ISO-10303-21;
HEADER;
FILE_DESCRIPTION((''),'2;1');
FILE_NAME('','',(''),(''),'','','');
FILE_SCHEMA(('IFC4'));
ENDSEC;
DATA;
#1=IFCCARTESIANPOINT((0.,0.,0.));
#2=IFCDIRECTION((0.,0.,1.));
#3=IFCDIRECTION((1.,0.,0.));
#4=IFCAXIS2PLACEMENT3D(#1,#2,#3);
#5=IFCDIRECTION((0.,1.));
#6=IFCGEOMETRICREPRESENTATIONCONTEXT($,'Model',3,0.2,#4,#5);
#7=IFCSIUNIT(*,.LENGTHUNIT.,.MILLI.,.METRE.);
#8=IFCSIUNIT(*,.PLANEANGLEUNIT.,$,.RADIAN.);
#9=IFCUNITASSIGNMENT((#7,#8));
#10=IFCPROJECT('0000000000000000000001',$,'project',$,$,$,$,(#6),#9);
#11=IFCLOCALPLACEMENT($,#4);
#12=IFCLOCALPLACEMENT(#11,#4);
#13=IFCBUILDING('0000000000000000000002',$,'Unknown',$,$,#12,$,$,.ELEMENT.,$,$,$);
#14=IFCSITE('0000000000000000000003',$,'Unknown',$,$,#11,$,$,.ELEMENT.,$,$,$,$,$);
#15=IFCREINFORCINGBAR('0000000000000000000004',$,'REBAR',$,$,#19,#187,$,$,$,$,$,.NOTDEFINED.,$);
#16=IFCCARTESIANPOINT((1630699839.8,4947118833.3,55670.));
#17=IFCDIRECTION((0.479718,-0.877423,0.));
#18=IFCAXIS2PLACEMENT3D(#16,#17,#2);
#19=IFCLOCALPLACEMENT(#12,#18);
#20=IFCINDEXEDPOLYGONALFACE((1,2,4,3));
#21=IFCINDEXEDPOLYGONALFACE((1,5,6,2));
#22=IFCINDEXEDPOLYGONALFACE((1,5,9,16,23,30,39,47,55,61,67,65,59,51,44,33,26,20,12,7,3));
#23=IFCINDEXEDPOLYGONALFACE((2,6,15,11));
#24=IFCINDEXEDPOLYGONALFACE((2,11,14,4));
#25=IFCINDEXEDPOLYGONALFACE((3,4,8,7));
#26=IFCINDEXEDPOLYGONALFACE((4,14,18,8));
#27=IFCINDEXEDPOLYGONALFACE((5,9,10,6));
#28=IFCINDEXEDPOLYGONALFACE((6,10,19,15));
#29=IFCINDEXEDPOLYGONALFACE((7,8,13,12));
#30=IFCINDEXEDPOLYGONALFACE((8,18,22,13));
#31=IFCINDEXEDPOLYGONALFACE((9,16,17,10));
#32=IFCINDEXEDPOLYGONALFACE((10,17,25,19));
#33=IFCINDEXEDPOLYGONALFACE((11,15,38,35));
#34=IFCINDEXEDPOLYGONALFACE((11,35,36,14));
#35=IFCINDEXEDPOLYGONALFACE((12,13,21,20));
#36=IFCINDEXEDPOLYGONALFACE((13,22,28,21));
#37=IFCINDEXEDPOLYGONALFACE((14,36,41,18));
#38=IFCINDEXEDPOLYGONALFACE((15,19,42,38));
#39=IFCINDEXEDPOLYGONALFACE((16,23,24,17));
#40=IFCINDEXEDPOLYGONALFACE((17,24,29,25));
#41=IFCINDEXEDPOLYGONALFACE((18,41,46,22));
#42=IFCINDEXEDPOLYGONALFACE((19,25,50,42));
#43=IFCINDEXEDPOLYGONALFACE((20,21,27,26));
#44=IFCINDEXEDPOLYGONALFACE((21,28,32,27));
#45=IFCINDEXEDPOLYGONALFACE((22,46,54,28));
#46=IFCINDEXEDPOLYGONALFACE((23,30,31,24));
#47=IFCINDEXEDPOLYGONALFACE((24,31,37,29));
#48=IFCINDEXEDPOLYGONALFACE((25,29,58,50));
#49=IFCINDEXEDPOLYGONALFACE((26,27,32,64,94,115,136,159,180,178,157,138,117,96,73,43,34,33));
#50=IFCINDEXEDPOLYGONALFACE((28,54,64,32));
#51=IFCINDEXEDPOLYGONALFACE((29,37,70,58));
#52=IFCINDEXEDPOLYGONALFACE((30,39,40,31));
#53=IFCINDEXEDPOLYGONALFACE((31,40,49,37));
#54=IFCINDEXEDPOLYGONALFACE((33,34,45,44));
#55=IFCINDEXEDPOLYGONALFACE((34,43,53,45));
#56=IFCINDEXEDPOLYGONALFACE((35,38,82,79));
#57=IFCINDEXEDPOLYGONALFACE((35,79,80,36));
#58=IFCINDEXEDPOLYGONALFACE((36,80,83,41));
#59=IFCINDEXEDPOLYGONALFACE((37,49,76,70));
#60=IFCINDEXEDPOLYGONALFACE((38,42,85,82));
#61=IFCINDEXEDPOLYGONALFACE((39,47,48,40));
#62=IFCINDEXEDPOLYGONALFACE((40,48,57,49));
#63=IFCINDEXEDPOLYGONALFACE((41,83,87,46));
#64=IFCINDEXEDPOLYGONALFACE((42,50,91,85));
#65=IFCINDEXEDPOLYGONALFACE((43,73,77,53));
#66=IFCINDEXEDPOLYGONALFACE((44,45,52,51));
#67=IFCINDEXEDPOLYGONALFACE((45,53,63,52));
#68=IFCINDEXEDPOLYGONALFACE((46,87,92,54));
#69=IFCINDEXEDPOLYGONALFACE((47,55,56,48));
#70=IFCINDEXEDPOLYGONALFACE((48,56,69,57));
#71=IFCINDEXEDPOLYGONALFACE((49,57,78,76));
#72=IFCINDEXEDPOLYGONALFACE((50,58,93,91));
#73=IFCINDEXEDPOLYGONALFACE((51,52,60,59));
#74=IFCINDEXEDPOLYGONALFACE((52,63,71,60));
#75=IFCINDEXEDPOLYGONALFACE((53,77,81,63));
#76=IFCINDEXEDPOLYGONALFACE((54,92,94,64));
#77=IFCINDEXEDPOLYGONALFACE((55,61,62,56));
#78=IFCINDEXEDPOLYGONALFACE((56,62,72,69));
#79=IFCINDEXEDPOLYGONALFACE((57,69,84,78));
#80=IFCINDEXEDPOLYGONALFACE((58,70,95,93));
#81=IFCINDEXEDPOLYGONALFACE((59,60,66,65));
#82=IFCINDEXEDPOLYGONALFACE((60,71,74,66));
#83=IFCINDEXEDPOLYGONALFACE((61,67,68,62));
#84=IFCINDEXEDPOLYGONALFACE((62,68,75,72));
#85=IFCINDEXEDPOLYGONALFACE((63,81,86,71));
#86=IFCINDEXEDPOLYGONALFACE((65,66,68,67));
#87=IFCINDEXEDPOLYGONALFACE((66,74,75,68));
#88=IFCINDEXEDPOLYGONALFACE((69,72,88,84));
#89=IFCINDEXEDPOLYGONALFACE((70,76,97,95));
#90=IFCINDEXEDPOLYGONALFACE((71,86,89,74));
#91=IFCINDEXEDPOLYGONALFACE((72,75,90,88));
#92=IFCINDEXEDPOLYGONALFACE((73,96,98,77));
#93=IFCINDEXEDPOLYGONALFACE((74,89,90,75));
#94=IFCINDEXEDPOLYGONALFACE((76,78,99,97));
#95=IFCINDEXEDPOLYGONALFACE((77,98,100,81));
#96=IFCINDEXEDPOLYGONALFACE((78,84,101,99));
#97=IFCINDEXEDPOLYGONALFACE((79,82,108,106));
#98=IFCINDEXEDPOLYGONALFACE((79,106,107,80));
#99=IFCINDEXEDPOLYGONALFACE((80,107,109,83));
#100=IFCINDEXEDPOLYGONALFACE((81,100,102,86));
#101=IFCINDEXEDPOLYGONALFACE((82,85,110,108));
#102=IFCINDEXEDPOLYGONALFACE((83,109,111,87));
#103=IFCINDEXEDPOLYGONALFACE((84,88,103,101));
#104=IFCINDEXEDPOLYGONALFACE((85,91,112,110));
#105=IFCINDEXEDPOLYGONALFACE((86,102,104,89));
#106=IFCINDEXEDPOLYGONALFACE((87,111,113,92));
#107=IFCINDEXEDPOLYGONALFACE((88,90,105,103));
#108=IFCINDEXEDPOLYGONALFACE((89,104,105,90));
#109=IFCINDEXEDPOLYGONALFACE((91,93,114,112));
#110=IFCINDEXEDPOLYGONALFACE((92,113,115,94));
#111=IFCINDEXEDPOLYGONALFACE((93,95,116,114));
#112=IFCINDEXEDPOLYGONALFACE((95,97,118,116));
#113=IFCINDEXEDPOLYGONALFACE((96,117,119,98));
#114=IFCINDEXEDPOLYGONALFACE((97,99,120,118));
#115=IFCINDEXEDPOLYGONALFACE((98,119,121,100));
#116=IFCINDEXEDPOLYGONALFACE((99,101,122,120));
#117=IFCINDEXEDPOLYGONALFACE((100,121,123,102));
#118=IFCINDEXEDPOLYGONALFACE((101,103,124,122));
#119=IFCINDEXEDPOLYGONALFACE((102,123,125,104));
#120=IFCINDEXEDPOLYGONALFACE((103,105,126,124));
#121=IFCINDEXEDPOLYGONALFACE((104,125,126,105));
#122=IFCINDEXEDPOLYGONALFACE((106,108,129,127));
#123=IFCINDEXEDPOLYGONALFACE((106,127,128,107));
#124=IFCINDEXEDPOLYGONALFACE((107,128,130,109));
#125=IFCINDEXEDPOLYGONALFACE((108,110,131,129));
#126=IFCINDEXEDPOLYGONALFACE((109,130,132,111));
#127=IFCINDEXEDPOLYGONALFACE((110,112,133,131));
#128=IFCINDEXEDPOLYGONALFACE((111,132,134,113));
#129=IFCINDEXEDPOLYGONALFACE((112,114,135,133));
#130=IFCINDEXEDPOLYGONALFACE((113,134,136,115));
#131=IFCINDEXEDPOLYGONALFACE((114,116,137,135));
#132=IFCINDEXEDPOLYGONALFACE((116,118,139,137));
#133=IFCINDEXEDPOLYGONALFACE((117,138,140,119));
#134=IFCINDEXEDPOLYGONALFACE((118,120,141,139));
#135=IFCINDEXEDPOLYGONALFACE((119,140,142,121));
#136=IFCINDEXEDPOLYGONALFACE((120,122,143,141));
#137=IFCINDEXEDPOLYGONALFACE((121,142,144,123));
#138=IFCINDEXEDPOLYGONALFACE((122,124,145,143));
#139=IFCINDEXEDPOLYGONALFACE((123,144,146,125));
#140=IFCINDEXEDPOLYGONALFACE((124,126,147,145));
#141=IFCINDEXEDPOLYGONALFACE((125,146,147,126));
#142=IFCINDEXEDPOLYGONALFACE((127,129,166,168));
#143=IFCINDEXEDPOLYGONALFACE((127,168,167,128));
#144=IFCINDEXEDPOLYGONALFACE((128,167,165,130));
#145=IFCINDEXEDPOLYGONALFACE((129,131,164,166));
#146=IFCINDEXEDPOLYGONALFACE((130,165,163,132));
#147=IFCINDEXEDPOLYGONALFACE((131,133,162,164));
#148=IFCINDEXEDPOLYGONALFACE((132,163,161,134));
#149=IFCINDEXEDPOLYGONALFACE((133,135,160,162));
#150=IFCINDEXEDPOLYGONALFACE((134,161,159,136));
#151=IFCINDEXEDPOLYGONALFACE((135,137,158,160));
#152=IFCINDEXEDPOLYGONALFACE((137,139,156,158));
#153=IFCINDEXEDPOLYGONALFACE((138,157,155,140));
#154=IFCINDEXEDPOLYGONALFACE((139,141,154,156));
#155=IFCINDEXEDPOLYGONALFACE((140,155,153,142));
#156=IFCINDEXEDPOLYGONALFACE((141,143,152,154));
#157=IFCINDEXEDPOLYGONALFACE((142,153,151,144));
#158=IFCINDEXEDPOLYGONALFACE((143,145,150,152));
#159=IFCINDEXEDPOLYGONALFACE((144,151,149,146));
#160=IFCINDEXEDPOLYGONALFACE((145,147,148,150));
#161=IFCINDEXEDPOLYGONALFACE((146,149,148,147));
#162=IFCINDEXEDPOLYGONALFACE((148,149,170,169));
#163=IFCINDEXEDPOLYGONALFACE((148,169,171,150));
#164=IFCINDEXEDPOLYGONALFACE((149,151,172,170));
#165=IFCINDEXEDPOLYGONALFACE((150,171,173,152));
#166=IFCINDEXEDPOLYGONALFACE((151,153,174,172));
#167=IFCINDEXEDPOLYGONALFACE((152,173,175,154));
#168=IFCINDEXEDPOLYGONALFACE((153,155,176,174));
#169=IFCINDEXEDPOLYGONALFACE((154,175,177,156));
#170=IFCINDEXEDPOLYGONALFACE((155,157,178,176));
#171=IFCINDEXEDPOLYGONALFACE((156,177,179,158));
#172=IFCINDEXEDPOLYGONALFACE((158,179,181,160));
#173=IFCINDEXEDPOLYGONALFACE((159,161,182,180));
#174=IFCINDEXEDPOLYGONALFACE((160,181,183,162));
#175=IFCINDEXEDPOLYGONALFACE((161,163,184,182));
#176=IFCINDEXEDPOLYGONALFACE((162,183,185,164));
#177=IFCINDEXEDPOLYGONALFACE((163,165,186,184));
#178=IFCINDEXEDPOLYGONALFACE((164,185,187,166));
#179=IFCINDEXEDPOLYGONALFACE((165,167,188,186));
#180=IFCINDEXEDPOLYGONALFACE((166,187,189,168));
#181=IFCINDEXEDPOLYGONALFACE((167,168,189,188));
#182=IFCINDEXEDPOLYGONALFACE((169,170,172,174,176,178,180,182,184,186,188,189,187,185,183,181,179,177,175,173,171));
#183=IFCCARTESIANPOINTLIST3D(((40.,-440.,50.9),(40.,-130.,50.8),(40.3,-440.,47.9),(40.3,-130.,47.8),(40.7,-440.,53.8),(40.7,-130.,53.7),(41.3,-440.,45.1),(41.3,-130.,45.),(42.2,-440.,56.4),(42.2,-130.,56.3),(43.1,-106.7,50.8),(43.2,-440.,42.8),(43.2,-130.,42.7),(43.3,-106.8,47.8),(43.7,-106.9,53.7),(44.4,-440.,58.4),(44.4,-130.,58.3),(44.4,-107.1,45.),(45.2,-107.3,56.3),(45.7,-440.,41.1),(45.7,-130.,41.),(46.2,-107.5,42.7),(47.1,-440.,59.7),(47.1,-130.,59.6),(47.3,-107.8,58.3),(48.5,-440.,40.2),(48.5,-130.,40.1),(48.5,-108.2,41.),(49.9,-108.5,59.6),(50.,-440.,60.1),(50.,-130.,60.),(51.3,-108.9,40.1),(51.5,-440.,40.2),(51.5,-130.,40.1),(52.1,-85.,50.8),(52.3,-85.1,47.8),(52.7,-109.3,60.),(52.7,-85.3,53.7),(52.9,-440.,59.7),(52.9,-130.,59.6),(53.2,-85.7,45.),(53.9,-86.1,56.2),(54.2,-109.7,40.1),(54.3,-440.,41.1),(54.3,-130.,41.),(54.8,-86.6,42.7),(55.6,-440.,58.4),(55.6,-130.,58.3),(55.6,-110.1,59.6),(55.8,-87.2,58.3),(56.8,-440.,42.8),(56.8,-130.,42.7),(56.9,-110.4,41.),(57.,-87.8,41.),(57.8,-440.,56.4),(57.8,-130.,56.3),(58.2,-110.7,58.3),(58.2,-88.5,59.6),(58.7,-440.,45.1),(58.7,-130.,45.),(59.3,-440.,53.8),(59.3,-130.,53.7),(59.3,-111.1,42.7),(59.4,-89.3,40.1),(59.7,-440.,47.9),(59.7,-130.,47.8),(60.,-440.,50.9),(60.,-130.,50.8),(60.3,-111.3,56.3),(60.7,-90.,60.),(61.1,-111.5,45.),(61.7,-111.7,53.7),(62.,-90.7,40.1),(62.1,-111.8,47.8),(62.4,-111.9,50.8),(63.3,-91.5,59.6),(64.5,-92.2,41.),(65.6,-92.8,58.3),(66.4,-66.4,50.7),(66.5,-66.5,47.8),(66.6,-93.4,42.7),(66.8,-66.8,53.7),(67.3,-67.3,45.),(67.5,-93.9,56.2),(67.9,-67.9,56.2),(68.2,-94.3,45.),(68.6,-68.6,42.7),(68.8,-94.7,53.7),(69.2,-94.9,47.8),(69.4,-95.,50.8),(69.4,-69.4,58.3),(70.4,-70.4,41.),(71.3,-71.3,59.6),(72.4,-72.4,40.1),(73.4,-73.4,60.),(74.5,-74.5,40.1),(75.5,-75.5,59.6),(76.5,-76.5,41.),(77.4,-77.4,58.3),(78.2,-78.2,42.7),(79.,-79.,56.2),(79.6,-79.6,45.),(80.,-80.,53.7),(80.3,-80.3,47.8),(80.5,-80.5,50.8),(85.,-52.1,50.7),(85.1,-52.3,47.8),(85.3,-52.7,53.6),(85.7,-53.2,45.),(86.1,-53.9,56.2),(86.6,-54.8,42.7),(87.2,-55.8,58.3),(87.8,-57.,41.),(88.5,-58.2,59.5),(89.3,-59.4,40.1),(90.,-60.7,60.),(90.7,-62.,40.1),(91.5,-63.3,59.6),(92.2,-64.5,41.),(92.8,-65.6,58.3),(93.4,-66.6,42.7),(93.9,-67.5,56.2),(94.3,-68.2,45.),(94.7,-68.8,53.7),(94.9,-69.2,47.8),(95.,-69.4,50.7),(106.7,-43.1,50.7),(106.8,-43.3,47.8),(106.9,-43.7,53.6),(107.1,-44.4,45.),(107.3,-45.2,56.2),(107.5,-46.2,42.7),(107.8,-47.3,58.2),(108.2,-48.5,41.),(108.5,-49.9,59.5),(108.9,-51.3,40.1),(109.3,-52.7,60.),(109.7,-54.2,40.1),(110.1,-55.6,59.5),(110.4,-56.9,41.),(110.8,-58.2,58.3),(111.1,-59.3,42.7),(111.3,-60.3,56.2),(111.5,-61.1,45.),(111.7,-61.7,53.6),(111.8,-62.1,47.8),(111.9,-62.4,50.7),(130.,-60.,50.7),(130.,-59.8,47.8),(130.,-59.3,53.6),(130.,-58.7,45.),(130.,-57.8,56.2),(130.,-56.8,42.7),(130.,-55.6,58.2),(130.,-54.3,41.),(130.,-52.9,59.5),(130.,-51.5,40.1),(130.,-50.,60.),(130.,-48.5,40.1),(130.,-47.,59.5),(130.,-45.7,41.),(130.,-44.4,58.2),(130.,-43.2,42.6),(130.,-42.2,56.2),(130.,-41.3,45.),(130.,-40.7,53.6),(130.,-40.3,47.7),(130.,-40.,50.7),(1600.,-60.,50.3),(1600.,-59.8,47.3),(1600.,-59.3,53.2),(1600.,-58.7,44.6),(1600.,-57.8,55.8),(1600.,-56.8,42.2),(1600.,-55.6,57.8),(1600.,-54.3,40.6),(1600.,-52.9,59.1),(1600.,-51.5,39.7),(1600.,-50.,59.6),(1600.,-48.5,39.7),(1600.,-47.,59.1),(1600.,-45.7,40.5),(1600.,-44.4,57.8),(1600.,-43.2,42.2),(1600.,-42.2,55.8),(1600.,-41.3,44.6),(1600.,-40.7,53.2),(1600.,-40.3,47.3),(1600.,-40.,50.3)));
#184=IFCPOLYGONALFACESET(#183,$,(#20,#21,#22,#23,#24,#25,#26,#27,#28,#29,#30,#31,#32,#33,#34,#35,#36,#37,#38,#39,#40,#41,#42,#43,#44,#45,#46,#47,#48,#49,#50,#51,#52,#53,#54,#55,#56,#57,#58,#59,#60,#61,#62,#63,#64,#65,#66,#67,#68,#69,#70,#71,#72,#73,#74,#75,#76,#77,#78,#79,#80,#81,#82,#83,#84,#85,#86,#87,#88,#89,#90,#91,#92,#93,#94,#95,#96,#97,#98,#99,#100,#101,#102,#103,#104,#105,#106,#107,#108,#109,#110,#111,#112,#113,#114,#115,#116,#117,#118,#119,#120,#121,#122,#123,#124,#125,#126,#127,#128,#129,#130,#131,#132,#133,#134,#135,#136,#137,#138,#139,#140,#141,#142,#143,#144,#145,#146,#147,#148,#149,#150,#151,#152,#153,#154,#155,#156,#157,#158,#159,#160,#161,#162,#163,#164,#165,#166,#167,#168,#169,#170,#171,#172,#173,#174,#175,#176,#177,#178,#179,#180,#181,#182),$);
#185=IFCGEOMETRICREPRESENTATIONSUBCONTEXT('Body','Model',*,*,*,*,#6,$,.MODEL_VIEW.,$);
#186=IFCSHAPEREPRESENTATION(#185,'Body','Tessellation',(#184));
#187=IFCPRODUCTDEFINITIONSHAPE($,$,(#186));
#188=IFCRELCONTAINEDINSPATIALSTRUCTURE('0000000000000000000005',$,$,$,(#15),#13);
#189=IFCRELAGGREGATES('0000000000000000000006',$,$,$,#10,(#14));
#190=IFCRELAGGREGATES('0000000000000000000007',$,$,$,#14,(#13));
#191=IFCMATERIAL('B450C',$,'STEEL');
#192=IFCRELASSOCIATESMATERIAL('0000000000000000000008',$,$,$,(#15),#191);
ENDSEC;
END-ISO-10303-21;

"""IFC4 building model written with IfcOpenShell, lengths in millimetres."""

from ifc_helpers import new_model, entity, si_unit, direction, frame, origin_with_axes, place, context, subcontext, project, spatial, material, element, save


model = new_model("IFC4")

# Units and contexts
model_context = context("Model", 3, precision=0.2, world=origin_with_axes(), true_north=direction((0.0, 1.0)))
body_context = subcontext(model_context, "Body", "Model", "MODEL_VIEW")
ifc_project = project(units=[si_unit("LENGTHUNIT", "METRE", prefix="MILLI"), si_unit("PLANEANGLEUNIT", "RADIAN")], contexts=[model_context])

# Site, building
site_placement = place(None, origin_with_axes())
site = spatial("IfcSite", under=ifc_project, at=site_placement, Name="Unknown", CompositionType="ELEMENT")
building_placement = place(site_placement, origin_with_axes())
building = spatial("IfcBuilding", under=site, at=building_placement, Name="Unknown", CompositionType="ELEMENT")

# Reinforcing bar
ifc_material = material(Name="B450C", Category="STEEL")
reinforcing_bar_1_placement = place(building_placement, frame((1630699839.8, 4947118833.3, 55670.0), z_axis=(0.479718, -0.877423, 0.0), x_axis=(0.0, 0.0, 1.0)))
element("IfcReinforcingBar", 1, at=reinforcing_bar_1_placement, inside=building, material=ifc_material, Name="REBAR", PredefinedType="NOTDEFINED", context=body_context, shape_type="AdvancedSweptSolid", body=[
    entity("IfcSweptDiskSolid", entity("IfcIndexedPolyCurve", entity("IfcCartesianPointList3D", [[50.0, -440.0, 50.1], [50.0, -130.0, 50.0], [73.4, -73.4, 50.0], [130.0, -50.0, 50.0], [1600.0, -50.0, 49.6]]), [entity("IfcLineIndex", [1, 2]), entity("IfcArcIndex", [2, 3, 4]), entity("IfcLineIndex", [4, 5])]), 10.0),
])

save(model, "model.ifc")
